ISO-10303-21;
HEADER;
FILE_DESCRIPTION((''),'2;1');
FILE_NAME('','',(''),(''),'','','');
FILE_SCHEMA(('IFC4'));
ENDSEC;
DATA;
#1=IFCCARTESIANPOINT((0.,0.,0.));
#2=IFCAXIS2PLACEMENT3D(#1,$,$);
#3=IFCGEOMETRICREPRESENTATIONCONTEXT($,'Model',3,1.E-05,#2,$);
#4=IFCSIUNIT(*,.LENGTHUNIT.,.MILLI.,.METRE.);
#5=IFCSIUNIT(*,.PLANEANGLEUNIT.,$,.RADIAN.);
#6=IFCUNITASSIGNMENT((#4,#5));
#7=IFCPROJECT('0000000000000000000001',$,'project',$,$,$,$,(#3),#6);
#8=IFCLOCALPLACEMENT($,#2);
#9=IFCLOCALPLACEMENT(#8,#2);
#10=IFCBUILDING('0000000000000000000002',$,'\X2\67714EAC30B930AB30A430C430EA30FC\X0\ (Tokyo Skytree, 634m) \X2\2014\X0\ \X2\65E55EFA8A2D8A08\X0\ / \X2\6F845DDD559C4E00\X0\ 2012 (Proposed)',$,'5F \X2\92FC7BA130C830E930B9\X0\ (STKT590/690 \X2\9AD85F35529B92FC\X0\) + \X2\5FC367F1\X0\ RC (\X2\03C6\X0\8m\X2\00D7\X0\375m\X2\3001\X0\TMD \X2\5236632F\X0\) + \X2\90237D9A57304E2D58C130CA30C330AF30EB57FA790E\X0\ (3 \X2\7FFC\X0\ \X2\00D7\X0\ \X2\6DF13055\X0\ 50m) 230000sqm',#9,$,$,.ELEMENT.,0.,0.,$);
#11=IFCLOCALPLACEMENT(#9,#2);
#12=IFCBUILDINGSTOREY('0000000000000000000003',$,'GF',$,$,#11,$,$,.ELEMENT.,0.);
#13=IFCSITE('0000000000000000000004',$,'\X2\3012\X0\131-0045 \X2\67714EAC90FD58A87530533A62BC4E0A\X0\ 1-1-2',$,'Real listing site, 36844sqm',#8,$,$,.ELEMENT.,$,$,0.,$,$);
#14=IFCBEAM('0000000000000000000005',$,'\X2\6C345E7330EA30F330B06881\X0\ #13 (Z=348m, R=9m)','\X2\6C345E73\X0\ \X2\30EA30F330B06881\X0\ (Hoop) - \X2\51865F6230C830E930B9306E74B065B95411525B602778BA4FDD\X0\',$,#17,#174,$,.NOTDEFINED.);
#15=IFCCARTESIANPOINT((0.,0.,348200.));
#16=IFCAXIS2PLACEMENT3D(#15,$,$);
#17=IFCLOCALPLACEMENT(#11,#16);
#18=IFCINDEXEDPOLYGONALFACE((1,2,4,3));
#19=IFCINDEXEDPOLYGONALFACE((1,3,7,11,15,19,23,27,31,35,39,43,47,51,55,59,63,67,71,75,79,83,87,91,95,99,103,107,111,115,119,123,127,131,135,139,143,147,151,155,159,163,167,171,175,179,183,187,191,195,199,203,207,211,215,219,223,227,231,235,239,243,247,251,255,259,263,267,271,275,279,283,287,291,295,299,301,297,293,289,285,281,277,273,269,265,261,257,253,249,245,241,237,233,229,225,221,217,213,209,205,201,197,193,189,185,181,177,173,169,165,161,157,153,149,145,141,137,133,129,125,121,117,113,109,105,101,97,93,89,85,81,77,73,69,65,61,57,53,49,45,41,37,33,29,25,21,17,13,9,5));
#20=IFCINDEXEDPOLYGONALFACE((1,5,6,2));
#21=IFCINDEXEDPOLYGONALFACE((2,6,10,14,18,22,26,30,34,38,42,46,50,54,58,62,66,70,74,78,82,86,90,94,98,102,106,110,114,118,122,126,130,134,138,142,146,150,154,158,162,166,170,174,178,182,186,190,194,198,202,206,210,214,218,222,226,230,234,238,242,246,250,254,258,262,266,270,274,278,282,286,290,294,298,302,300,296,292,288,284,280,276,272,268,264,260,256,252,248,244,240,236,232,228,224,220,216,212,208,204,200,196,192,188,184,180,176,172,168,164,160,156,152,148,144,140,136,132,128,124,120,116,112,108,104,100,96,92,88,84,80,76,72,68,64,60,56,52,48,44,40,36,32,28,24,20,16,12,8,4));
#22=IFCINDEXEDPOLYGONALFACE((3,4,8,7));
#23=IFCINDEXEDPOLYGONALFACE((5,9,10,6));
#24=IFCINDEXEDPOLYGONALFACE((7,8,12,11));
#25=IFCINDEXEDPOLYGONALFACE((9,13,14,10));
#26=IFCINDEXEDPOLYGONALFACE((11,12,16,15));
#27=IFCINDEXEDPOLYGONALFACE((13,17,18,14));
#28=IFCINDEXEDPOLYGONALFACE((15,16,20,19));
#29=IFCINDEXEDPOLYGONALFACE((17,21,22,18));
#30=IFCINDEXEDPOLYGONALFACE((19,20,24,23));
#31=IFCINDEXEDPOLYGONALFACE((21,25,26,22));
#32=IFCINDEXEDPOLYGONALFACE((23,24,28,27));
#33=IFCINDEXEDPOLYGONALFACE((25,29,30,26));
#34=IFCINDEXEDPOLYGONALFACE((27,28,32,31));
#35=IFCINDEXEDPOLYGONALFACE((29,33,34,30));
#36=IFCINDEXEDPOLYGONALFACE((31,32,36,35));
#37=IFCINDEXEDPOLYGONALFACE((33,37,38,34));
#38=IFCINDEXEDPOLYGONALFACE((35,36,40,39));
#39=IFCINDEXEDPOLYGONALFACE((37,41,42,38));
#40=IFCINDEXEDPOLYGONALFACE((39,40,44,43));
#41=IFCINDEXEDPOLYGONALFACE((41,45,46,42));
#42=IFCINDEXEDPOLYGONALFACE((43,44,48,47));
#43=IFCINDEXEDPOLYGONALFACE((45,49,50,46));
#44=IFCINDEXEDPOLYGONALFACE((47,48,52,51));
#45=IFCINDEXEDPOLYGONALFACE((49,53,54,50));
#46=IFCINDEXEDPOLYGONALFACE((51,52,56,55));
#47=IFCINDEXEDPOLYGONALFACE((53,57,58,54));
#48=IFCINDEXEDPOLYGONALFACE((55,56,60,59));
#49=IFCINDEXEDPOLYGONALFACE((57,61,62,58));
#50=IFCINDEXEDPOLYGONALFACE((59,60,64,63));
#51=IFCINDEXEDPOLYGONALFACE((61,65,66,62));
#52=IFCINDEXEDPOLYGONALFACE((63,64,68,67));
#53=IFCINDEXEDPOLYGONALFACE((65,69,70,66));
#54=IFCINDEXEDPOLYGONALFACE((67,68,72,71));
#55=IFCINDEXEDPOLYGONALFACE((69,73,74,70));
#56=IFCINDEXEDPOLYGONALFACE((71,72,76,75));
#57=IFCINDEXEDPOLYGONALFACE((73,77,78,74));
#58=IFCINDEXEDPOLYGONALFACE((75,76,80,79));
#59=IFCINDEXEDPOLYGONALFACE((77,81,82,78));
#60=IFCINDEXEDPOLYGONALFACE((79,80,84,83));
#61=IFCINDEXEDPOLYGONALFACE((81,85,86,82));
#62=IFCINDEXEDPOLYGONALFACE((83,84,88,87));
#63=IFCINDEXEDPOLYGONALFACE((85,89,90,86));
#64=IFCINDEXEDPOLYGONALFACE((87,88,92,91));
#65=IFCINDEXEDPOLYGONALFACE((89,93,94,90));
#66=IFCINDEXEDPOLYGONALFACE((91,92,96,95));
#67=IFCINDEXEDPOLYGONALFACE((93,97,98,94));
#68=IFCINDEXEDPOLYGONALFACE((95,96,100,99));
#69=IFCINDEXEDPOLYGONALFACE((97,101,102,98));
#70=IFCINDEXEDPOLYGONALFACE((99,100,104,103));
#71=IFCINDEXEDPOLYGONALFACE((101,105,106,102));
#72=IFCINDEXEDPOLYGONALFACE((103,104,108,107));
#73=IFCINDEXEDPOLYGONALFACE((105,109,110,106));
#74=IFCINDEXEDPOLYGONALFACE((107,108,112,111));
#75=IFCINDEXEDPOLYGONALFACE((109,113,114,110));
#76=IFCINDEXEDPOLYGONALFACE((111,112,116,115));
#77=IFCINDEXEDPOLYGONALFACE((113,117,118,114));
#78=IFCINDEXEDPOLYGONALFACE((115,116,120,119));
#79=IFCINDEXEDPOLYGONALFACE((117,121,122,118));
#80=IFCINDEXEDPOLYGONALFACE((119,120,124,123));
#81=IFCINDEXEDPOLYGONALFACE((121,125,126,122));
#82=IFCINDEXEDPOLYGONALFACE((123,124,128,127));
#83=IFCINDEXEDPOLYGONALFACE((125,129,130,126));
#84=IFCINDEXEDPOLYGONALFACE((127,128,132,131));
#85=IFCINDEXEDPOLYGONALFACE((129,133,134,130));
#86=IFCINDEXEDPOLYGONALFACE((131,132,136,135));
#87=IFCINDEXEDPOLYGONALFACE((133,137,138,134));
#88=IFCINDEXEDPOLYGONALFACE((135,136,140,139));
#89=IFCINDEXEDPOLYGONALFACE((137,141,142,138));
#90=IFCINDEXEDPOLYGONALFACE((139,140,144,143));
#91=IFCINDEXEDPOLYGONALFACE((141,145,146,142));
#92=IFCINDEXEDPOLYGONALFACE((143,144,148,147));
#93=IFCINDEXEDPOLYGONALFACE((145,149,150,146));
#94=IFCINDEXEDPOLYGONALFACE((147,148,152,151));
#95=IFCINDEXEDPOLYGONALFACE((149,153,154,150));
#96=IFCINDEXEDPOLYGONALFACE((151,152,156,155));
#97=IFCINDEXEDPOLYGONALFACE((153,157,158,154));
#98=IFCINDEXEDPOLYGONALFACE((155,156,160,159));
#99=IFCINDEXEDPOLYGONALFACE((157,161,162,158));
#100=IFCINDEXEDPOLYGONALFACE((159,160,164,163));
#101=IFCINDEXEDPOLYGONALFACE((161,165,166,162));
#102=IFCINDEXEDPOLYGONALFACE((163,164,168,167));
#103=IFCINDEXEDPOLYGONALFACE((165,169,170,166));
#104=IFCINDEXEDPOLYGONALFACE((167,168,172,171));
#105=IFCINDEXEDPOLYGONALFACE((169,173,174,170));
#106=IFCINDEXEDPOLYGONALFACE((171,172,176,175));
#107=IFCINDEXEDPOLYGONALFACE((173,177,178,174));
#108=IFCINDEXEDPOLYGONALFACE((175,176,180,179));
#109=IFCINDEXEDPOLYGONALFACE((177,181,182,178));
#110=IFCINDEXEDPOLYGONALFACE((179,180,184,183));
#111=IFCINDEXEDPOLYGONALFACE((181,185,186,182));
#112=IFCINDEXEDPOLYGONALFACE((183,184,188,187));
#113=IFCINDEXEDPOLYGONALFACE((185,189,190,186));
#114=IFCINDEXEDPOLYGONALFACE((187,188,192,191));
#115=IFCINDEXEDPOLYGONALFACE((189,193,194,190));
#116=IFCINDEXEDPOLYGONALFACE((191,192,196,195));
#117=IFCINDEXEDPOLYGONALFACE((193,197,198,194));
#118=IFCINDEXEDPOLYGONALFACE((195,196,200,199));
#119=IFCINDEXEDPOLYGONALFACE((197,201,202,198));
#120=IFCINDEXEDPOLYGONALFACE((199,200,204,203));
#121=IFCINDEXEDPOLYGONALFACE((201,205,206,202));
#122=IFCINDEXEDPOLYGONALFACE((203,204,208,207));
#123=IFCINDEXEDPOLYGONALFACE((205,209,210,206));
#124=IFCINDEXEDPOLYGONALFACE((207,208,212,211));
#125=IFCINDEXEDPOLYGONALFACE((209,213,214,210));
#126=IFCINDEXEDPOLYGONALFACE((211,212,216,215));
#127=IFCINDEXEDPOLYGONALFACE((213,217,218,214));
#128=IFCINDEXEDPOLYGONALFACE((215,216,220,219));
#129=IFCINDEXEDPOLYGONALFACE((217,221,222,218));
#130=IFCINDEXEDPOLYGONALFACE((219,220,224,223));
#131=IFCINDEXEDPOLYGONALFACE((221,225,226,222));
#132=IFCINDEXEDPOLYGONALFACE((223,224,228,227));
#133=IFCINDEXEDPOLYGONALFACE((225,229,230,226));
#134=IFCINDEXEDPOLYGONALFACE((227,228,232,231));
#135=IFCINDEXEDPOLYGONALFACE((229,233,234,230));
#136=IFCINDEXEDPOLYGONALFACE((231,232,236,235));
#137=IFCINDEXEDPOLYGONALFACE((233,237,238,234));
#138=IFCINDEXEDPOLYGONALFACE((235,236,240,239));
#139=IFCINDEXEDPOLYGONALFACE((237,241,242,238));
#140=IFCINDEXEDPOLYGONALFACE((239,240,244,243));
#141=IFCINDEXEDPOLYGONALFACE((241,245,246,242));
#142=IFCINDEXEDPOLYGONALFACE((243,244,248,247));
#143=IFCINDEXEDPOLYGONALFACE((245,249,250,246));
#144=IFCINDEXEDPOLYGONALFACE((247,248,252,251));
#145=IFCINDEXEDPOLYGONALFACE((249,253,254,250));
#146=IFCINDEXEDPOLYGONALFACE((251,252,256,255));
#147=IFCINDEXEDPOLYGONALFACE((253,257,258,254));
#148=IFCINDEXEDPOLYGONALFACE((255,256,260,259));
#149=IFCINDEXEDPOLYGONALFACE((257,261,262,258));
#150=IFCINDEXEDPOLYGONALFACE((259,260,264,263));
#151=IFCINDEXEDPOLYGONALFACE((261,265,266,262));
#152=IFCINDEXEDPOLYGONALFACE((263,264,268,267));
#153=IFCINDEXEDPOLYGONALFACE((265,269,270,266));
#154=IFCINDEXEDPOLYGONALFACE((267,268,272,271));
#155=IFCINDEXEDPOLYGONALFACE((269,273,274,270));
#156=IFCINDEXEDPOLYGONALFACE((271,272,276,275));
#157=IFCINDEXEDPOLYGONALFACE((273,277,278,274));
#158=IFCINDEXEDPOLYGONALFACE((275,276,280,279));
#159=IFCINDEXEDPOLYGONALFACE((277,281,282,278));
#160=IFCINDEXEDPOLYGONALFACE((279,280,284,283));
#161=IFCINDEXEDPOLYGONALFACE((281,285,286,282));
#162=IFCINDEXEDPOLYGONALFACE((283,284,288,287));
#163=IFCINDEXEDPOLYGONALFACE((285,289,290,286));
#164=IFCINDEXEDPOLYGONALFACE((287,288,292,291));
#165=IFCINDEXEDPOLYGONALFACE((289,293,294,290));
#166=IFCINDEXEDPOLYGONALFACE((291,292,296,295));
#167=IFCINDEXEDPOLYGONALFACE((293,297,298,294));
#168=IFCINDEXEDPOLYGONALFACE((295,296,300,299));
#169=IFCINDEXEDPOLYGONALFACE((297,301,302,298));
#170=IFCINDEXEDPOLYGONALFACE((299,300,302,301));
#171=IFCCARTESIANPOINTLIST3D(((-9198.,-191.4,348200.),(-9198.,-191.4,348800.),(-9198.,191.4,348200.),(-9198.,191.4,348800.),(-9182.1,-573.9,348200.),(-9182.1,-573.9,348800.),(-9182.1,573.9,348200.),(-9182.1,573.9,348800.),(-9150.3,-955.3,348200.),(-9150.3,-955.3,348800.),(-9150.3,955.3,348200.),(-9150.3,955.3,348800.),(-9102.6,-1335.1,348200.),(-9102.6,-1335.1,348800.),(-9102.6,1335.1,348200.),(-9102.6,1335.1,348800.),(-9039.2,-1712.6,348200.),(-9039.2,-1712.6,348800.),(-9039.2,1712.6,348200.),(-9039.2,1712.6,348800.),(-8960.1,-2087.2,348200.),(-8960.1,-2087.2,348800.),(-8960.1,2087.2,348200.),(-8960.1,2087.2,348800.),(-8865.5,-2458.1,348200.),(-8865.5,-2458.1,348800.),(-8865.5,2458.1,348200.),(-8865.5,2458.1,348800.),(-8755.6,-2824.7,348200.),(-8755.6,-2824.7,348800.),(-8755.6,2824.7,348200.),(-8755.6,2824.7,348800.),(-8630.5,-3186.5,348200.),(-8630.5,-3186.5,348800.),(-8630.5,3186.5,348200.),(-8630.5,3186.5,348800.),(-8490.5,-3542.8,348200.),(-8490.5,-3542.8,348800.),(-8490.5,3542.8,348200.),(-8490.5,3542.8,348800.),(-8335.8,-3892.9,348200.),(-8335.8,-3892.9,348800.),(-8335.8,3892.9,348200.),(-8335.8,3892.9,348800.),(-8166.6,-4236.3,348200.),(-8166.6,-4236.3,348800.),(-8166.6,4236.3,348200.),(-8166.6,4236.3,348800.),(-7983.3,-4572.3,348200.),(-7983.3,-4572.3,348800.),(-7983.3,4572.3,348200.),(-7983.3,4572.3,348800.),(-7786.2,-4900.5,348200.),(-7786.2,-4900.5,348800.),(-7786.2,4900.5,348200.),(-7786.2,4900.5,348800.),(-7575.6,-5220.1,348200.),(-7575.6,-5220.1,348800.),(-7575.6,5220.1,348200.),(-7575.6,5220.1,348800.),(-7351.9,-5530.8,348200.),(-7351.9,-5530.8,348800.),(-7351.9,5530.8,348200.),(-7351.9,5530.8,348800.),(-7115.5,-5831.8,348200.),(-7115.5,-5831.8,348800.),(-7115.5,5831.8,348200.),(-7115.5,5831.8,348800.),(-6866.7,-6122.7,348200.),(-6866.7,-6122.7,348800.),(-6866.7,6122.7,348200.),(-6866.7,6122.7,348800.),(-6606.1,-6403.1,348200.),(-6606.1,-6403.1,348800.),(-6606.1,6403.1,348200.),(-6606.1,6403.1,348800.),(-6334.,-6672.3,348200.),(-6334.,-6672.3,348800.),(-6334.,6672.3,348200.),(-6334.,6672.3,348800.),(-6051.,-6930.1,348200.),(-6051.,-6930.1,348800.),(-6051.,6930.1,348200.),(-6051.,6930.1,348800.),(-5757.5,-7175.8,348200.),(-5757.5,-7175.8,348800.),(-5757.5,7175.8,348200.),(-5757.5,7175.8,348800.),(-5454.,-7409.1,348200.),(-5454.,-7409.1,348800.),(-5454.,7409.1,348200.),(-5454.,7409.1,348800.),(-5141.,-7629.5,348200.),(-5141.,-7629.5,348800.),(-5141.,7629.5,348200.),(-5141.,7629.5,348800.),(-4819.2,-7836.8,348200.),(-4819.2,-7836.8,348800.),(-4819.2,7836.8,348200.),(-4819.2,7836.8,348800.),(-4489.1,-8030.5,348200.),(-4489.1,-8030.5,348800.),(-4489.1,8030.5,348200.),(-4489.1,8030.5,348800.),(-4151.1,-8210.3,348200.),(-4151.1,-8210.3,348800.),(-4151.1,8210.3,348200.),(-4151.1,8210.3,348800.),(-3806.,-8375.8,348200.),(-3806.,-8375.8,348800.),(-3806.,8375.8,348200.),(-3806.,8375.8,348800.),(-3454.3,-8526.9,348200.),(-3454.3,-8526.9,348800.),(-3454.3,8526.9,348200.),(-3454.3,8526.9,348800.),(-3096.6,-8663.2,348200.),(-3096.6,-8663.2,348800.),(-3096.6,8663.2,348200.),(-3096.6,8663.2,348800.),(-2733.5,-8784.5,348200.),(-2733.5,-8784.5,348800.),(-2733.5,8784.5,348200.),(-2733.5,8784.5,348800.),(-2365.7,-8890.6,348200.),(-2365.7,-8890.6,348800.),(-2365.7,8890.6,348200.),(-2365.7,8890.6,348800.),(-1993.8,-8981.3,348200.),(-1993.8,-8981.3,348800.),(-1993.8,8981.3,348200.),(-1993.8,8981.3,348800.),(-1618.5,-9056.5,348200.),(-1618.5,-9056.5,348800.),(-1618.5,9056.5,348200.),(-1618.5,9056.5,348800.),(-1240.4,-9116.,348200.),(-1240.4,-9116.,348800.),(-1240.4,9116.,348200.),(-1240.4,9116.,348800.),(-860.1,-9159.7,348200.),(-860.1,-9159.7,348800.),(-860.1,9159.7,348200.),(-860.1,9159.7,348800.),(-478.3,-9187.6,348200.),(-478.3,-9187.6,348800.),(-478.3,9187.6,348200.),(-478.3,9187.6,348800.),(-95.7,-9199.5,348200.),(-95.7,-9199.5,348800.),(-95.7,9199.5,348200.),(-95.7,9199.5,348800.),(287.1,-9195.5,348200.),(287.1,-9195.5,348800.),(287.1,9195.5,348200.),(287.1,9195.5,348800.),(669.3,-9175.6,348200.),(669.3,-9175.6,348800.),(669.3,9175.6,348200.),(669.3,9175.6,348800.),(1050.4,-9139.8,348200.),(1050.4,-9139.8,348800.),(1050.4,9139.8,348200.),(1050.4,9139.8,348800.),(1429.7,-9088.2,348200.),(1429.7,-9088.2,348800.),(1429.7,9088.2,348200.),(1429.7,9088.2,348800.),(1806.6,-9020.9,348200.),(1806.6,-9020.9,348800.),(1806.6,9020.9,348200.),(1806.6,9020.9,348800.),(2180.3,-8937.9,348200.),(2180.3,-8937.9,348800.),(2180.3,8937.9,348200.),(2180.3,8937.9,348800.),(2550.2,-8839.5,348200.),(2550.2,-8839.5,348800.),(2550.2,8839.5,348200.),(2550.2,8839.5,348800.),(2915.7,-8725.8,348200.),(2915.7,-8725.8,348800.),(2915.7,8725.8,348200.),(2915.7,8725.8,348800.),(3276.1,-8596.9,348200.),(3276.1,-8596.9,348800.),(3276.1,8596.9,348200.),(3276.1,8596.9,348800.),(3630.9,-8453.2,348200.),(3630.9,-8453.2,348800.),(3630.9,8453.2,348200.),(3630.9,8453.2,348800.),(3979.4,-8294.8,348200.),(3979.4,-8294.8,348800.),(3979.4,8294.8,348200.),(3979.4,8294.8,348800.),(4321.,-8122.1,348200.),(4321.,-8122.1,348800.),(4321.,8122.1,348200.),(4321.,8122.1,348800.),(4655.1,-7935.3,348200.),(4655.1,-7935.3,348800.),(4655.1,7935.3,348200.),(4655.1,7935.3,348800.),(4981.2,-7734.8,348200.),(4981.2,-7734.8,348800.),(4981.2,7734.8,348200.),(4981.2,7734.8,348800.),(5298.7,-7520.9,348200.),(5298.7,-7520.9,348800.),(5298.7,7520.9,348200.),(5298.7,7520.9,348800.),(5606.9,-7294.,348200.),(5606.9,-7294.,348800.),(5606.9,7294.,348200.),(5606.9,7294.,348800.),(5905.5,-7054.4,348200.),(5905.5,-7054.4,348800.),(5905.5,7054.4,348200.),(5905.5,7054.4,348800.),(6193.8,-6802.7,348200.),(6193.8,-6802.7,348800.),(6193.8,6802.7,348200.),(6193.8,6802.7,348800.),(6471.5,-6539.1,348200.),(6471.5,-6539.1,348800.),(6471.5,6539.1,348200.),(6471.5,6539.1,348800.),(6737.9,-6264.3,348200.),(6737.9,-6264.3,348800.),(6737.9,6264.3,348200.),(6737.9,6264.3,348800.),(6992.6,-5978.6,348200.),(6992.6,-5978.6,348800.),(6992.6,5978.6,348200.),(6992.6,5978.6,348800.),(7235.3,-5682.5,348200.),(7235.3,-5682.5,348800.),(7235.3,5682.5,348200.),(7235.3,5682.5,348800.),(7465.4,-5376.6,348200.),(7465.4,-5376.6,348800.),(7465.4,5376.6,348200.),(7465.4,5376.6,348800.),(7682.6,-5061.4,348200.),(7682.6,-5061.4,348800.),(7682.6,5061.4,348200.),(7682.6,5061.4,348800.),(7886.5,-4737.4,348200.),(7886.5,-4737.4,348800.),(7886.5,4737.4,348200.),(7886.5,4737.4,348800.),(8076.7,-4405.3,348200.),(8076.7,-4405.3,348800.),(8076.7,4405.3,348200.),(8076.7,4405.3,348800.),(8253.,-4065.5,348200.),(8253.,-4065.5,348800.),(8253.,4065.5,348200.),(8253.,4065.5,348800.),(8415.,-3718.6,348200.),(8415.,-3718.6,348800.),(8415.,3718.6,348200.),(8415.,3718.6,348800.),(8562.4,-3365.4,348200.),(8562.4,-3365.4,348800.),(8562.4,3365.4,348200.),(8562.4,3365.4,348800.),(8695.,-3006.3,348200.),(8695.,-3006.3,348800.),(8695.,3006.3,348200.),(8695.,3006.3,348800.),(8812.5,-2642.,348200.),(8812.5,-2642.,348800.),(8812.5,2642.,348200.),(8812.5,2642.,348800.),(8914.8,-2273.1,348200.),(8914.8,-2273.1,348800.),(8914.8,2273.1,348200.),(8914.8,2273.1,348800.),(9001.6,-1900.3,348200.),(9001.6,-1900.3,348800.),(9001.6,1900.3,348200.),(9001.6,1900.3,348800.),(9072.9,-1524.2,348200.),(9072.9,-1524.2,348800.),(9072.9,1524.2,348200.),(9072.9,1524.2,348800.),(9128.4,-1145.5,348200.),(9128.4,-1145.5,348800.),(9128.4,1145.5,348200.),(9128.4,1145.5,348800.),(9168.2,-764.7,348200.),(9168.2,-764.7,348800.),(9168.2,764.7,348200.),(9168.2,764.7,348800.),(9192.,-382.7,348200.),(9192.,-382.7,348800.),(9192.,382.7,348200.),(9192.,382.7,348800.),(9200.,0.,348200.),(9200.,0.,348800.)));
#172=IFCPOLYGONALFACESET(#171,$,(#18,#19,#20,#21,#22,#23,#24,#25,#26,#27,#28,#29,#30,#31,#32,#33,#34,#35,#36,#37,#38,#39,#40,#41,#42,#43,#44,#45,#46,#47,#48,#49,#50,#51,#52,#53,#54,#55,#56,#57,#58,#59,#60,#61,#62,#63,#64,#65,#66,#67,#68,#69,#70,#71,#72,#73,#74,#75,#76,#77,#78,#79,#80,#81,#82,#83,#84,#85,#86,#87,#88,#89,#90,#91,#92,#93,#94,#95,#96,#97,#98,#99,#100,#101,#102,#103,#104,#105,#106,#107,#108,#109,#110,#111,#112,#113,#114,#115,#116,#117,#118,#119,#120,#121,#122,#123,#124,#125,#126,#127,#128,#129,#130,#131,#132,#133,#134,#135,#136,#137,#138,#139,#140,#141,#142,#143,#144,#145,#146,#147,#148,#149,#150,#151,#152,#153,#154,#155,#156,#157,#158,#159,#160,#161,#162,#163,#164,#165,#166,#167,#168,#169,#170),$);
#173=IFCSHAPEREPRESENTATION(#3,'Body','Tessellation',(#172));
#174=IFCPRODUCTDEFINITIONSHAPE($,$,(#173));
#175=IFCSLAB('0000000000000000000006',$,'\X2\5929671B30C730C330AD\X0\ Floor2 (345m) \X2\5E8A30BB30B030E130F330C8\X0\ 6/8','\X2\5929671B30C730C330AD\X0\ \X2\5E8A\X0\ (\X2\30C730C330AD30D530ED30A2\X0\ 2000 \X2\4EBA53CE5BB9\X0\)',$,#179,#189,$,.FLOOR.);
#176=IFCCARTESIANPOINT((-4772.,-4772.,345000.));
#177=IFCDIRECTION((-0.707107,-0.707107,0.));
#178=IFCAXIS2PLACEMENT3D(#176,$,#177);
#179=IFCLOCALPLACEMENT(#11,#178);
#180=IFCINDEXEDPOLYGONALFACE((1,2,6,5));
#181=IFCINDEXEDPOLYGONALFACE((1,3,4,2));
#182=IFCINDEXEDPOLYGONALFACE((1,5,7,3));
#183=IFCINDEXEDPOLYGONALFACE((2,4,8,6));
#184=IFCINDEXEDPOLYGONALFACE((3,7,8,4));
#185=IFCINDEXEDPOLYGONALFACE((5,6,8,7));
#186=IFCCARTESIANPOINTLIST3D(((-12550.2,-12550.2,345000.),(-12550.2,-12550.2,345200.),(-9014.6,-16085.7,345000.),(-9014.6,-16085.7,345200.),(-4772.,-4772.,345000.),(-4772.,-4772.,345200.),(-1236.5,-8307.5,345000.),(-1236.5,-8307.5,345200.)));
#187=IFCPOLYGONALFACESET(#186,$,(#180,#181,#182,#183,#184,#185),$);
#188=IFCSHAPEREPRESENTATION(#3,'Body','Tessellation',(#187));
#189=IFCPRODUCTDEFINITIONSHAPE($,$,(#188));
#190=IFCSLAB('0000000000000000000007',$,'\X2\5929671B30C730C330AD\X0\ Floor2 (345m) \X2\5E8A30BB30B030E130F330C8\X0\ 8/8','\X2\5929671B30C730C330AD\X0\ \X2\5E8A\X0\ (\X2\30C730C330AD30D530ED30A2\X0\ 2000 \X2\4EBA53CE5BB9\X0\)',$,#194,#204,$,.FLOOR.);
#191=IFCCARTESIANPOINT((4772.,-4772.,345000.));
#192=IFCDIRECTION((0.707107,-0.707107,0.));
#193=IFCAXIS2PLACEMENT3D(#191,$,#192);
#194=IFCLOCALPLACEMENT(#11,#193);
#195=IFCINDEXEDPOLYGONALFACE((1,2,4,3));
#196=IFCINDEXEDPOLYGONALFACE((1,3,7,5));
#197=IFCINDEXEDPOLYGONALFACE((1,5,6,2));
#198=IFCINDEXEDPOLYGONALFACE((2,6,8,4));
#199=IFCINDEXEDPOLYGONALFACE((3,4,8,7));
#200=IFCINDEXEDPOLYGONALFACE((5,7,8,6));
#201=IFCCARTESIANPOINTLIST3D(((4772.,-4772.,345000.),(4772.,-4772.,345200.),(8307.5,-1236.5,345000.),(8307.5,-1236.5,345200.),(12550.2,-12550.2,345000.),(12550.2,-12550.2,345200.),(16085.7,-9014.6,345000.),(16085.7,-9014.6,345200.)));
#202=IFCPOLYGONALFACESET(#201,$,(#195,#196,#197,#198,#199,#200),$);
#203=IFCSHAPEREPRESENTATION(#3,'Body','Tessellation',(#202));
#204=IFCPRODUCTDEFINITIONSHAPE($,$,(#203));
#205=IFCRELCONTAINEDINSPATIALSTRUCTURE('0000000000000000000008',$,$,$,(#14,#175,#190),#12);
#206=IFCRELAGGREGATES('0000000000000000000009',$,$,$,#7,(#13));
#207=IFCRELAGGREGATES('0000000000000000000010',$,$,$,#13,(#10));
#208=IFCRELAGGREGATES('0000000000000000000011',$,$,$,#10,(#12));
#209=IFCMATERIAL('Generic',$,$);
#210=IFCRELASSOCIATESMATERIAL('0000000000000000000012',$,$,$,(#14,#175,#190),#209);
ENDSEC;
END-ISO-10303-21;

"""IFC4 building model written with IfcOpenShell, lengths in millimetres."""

from ifc_helpers import new_model, si_unit, frame, frame_2d, origin, origin_2d, place, context, project, spatial, rectangle, circle, extrude, material, element, save


model = new_model("IFC4")

# Units and contexts
model_context = context("Model", 3, precision=1e-05, world=origin())
ifc_project = project(units=[si_unit("LENGTHUNIT", "METRE", prefix="MILLI"), si_unit("PLANEANGLEUNIT", "RADIAN")], contexts=[model_context])

# Site, building, storey
site_placement = place(None, origin())
site = spatial("IfcSite", under=ifc_project, at=site_placement, Name="〒131-0045 東京都墨田区押上 1-1-2", ObjectType="Real listing site, 36844sqm", CompositionType="ELEMENT", RefElevation=0.0)
building_placement = place(site_placement, origin())
building = spatial("IfcBuilding", under=site, at=building_placement, Name="東京スカイツリー (Tokyo Skytree, 634m) — 日建設計 / 澄川喜一 2012 (Proposed)", ObjectType="5F 鋼管トラス (STKT590/690 高張力鋼) + 心柱 RC (φ8m×375m、TMD 制振) + 連続地中壁ナックル基礎 (3 翼 × 深さ 50m) 230000sqm", CompositionType="ELEMENT", ElevationOfRefHeight=0.0, ElevationOfTerrain=0.0)
storey_placement = place(building_placement, origin())
storey = spatial("IfcBuildingStorey", under=building, at=storey_placement, Name="GF", CompositionType="ELEMENT", Elevation=0.0)

# Shared definitions
ifc_material_1 = material(Name="Generic")

# Beam
beam_placement = place(storey_placement, frame((0.0, 0.0, 348200.0)))
element("IfcBeam", 1, at=beam_placement, inside=storey, material=ifc_material_1, Name="水平リング梁 #13 (Z=348m, R=9m)", Description="水平 リング梁 (Hoop) - 円形トラスの環方向剛性確保", PredefinedType="NOTDEFINED", context=model_context, shape_type="SweptSolid", body=[
    extrude(circle(Radius=9200.0, at=origin_2d()), frame((0.0, 0.0, 348200.0)), (0.0, 0.0, 1.0), 600.0),
])

# Slabs
slab_1_placement = place(storey_placement, frame((-4772.0, -4772.0, 345000.0), x_axis=(-0.707107, -0.707107, 0.0)))
element("IfcSlab", 2, at=slab_1_placement, inside=storey, material=ifc_material_1, Name="天望デッキ Floor2 (345m) 床セグメント 6/8", Description="天望デッキ 床 (デッキフロア 2000 人収容)", PredefinedType="FLOOR", context=model_context, shape_type="SweptSolid", body=[
    extrude(rectangle(XDim=11000.0, YDim=5000.0, at=frame_2d((5500.0, 2500.0))), frame((-4772.0, -4772.0, 345000.0), x_axis=(-0.707107, -0.707107, 0.0)), (0.0, 0.0, 1.0), 200.0),
])
slab_2_placement = place(storey_placement, frame((4772.0, -4772.0, 345000.0), x_axis=(0.707107, -0.707107, 0.0)))
element("IfcSlab", 3, at=slab_2_placement, inside=storey, material=ifc_material_1, Name="天望デッキ Floor2 (345m) 床セグメント 8/8", Description="天望デッキ 床 (デッキフロア 2000 人収容)", PredefinedType="FLOOR", context=model_context, shape_type="SweptSolid", body=[
    extrude(rectangle(XDim=11000.0, YDim=5000.0, at=frame_2d((5500.0, 2500.0))), frame((4772.0, -4772.0, 345000.0), x_axis=(0.707107, -0.707107, 0.0)), (0.0, 0.0, 1.0), 200.0),
])

save(model, "model.ifc")
